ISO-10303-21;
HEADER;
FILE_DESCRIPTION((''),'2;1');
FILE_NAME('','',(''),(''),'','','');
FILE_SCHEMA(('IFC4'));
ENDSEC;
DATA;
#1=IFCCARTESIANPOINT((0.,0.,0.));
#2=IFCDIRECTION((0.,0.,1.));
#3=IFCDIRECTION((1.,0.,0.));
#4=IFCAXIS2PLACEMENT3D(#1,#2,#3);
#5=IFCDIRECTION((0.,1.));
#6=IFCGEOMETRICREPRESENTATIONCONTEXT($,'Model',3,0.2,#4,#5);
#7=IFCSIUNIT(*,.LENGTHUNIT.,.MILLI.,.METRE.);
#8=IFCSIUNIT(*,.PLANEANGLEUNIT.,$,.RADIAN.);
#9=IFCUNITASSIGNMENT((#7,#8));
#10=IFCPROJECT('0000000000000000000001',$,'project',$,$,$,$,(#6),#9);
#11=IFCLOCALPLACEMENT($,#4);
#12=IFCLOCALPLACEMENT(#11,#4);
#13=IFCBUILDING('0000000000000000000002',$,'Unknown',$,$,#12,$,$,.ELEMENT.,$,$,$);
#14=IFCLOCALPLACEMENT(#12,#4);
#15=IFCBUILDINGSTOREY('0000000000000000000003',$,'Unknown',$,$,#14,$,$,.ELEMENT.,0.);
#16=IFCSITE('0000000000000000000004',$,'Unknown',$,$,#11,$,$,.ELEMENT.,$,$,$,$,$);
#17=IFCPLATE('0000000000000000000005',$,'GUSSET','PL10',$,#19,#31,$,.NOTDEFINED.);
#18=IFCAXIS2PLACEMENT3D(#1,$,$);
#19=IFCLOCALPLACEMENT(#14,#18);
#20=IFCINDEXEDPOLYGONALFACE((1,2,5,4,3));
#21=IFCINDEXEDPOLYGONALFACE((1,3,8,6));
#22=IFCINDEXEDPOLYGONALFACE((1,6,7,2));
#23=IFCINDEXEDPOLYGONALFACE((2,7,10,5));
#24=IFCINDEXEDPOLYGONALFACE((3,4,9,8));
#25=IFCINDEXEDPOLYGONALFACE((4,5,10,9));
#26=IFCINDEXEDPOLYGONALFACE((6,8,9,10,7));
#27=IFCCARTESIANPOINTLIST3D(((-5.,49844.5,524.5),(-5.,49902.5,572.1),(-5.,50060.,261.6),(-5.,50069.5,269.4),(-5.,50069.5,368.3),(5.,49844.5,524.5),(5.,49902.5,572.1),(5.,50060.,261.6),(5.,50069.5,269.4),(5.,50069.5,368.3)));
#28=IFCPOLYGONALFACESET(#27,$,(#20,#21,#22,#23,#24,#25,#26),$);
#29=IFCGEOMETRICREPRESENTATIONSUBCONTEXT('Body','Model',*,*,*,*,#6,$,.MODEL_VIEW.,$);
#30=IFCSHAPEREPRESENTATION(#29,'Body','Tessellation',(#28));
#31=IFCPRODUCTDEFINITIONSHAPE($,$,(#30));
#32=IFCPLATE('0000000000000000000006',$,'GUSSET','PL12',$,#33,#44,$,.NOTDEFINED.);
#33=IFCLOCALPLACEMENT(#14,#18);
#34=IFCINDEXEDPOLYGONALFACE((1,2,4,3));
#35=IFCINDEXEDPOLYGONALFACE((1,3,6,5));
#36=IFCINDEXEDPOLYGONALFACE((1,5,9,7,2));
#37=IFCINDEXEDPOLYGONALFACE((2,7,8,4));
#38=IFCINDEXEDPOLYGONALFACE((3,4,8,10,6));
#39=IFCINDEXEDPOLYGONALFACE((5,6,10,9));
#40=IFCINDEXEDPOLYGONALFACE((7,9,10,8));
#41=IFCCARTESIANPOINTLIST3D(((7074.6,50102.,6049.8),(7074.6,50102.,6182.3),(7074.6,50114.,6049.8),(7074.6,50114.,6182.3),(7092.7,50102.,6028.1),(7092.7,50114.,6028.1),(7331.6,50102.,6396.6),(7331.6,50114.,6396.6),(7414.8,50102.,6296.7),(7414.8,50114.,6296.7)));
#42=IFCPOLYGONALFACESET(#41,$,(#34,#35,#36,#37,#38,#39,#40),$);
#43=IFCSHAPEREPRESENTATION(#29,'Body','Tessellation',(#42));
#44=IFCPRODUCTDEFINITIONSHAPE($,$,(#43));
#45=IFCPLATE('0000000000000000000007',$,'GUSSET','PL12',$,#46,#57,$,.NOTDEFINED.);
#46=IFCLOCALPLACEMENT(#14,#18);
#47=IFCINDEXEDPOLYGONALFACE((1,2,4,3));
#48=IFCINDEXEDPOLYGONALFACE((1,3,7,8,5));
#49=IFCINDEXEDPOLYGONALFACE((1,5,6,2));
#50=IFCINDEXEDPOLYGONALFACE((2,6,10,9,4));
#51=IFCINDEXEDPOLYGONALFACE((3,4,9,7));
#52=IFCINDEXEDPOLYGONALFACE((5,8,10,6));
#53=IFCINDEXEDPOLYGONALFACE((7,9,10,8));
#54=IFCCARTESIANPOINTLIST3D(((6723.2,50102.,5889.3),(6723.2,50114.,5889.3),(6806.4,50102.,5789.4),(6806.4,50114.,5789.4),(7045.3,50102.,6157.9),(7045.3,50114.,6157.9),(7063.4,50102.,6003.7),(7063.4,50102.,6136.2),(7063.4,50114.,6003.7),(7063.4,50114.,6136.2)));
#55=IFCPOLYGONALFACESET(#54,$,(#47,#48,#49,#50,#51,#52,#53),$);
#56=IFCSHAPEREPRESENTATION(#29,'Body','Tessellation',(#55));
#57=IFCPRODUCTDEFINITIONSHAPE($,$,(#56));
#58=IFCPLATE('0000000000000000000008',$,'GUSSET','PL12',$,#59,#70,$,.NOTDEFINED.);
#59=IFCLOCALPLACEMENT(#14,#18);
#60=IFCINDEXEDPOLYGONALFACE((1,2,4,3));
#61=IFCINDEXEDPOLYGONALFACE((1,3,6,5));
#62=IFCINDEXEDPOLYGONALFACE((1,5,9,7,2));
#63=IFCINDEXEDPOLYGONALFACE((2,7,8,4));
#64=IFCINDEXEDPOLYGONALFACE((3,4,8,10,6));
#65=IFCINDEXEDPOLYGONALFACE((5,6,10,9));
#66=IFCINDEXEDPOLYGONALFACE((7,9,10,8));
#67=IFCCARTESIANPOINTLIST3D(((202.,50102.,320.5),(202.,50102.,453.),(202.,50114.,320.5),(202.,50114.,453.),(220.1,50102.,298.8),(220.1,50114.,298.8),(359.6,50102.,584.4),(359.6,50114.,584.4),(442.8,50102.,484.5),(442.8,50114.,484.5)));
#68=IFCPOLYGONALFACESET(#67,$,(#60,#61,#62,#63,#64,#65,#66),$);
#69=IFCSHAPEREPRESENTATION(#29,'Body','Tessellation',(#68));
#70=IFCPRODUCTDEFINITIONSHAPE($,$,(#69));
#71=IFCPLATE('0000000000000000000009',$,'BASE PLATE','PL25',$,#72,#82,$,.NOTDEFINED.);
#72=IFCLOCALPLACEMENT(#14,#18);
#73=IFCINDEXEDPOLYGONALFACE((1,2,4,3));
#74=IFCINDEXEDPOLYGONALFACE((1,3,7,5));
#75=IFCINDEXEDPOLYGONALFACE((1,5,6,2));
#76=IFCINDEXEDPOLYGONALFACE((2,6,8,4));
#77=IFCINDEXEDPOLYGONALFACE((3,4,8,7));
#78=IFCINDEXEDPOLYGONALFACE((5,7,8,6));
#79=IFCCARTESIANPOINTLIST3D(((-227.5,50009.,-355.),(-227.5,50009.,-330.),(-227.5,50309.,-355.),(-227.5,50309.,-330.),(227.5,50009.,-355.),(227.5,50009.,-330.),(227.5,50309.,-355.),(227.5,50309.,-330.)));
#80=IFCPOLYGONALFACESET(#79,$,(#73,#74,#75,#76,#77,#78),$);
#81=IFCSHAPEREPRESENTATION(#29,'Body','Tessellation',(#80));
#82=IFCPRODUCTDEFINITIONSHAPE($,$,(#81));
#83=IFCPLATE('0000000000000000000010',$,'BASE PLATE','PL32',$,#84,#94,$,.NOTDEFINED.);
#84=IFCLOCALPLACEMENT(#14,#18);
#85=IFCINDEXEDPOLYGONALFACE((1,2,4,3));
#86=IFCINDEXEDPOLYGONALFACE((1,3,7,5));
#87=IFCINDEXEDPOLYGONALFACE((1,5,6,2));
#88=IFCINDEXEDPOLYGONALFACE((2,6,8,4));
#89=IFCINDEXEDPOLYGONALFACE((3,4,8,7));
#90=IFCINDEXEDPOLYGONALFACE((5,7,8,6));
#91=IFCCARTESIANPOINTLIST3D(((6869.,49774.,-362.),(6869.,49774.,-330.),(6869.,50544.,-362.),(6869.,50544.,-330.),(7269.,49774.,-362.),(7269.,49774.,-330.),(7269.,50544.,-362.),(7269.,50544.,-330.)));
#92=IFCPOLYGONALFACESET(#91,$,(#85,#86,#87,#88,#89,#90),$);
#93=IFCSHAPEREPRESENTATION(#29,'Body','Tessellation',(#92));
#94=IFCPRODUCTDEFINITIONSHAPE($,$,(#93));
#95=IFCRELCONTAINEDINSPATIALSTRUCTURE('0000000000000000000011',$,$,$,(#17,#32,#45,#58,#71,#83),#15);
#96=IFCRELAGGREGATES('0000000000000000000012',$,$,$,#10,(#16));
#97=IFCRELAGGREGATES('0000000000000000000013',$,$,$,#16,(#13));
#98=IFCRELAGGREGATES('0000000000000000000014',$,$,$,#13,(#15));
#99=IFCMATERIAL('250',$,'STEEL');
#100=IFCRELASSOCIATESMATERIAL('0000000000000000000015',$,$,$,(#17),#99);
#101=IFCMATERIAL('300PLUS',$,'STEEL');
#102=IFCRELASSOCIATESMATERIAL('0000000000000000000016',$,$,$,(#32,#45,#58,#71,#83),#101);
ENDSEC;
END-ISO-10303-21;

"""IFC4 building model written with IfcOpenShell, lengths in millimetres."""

from ifc_helpers import new_model, si_unit, direction, frame, origin_with_axes, place, context, subcontext, project, spatial, line, indexed_curve, outline, extrude, material, element, save


model = new_model("IFC4")

# Units and contexts
model_context = context("Model", 3, precision=0.2, world=origin_with_axes(), true_north=direction((0.0, 1.0)))
body_context = subcontext(model_context, "Body", "Model", "MODEL_VIEW")
ifc_project = project(units=[si_unit("LENGTHUNIT", "METRE", prefix="MILLI"), si_unit("PLANEANGLEUNIT", "RADIAN")], contexts=[model_context])

# Site, building, storey
site_placement = place(None, origin_with_axes())
site = spatial("IfcSite", under=ifc_project, at=site_placement, Name="Unknown", CompositionType="ELEMENT")
building_placement = place(site_placement, origin_with_axes())
building = spatial("IfcBuilding", under=site, at=building_placement, Name="Unknown", CompositionType="ELEMENT")
storey_placement = place(building_placement, origin_with_axes())
storey = spatial("IfcBuildingStorey", under=building, at=storey_placement, Name="Unknown", CompositionType="ELEMENT", Elevation=0.0)

# Shared definitions
ifc_material_1 = material(Name="300PLUS", Category="STEEL")

# Plates
ifc_material_2 = material(Name="250", Category="STEEL")
plate_1_placement = place(storey_placement, frame((0.0, 50069.5, 269.4), z_axis=(-1.0, 0.0, 0.0), x_axis=(0.0, -0.772869, -0.634566)))
element("IfcPlate", 1, at=plate_1_placement, inside=storey, material=ifc_material_2, Name="GUSSET", Description="PL10", PredefinedType="NOTDEFINED", context=body_context, shape_type="SolidModel", body=[
    extrude(outline(indexed_curve([(0.0, 0.0), (12.3, 0.0), (12.0, 339.9), (-63.0, 339.9), (-62.8, 76.4)], segments=[line(1, 2, 3, 4, 5, 1)])), frame((0.0, 0.0, 5.0), z_axis=(0.0, 0.0, 1.0), x_axis=(1.0, 0.0, 0.0)), (0.0, 0.0, -1.0), 10.0),
])
for number, where, z_axis, x_axis, name in (
    (2, (7074.6, 50108.0, 6049.8), (0.0, -1.0, 0.0), (0.640532, 0.0, -0.767931), "GUSSET"),
    (3, (7063.4, 50108.0, 6136.2), (0.0, -1.0, 0.0), (-0.640532, 0.0, 0.767931), "GUSSET"),
):
    element("IfcPlate", number, at=place(storey_placement, frame(where, z_axis=z_axis, x_axis=x_axis)), inside=storey, material=ifc_material_1, Name=name, Description="PL12", PredefinedType="NOTDEFINED", context=body_context, shape_type="SolidModel", body=[
        extrude(outline(indexed_curve([(0.0, 0.0), (28.3, 0.0), (28.3, 419.4), (-101.7, 419.5), (-101.8, 84.9)], segments=[line(1, 2, 3, 4, 5, 1)])), frame((0.0, 0.0, 6.0), z_axis=(0.0, 0.0, 1.0), x_axis=(1.0, 0.0, 0.0)), (0.0, 0.0, -1.0), 12.0),
    ])
plate_2_placement = place(storey_placement, frame((202.0, 50108.0, 320.5), z_axis=(0.0, -1.0, 0.0), x_axis=(0.640532, 0.0, -0.767931)))
element("IfcPlate", 4, at=plate_2_placement, inside=storey, material=ifc_material_1, Name="GUSSET", Description="PL12", PredefinedType="NOTDEFINED", context=body_context, shape_type="SolidModel", body=[
    extrude(outline(indexed_curve([(0.0, 0.0), (28.3, 0.0), (28.3, 290.0), (-101.7, 290.1), (-101.8, 84.9)], segments=[line(1, 2, 3, 4, 5, 1)])), frame((0.0, 0.0, 6.0), z_axis=(0.0, 0.0, 1.0), x_axis=(1.0, 0.0, 0.0)), (0.0, 0.0, -1.0), 12.0),
])
plate_3_placement = place(storey_placement, frame((-227.5, 50009.0, -342.5), z_axis=(0.0, 0.0, 1.0), x_axis=(1.0, 0.0, 0.0)))
element("IfcPlate", 5, at=plate_3_placement, inside=storey, material=ifc_material_1, Name="BASE PLATE", Description="PL25", PredefinedType="NOTDEFINED", context=body_context, shape_type="SolidModel", body=[
    extrude(outline(indexed_curve([(0.0, 0.0), (455.0, 0.0), (455.0, 300.0), (0.0, 300.0)], segments=[line(1, 2, 3, 4, 1)])), frame((0.0, 0.0, 12.5), z_axis=(0.0, 0.0, 1.0), x_axis=(1.0, 0.0, 0.0)), (0.0, 0.0, -1.0), 25.0),
])
plate_4_placement = place(storey_placement, frame((7269.0, 49774.0, -346.0), z_axis=(0.0, 0.0, 1.0), x_axis=(0.0, 1.0, 0.0)))
element("IfcPlate", 6, at=plate_4_placement, inside=storey, material=ifc_material_1, Name="BASE PLATE", Description="PL32", PredefinedType="NOTDEFINED", context=body_context, shape_type="SolidModel", body=[
    extrude(outline(indexed_curve([(0.0, 0.0), (770.0, 0.0), (770.0, 400.0), (0.0, 400.0)], segments=[line(1, 2, 3, 4, 1)])), frame((0.0, 0.0, 16.0), z_axis=(0.0, 0.0, 1.0), x_axis=(1.0, 0.0, 0.0)), (0.0, 0.0, -1.0), 32.0),
])

save(model, "model.ifc")
